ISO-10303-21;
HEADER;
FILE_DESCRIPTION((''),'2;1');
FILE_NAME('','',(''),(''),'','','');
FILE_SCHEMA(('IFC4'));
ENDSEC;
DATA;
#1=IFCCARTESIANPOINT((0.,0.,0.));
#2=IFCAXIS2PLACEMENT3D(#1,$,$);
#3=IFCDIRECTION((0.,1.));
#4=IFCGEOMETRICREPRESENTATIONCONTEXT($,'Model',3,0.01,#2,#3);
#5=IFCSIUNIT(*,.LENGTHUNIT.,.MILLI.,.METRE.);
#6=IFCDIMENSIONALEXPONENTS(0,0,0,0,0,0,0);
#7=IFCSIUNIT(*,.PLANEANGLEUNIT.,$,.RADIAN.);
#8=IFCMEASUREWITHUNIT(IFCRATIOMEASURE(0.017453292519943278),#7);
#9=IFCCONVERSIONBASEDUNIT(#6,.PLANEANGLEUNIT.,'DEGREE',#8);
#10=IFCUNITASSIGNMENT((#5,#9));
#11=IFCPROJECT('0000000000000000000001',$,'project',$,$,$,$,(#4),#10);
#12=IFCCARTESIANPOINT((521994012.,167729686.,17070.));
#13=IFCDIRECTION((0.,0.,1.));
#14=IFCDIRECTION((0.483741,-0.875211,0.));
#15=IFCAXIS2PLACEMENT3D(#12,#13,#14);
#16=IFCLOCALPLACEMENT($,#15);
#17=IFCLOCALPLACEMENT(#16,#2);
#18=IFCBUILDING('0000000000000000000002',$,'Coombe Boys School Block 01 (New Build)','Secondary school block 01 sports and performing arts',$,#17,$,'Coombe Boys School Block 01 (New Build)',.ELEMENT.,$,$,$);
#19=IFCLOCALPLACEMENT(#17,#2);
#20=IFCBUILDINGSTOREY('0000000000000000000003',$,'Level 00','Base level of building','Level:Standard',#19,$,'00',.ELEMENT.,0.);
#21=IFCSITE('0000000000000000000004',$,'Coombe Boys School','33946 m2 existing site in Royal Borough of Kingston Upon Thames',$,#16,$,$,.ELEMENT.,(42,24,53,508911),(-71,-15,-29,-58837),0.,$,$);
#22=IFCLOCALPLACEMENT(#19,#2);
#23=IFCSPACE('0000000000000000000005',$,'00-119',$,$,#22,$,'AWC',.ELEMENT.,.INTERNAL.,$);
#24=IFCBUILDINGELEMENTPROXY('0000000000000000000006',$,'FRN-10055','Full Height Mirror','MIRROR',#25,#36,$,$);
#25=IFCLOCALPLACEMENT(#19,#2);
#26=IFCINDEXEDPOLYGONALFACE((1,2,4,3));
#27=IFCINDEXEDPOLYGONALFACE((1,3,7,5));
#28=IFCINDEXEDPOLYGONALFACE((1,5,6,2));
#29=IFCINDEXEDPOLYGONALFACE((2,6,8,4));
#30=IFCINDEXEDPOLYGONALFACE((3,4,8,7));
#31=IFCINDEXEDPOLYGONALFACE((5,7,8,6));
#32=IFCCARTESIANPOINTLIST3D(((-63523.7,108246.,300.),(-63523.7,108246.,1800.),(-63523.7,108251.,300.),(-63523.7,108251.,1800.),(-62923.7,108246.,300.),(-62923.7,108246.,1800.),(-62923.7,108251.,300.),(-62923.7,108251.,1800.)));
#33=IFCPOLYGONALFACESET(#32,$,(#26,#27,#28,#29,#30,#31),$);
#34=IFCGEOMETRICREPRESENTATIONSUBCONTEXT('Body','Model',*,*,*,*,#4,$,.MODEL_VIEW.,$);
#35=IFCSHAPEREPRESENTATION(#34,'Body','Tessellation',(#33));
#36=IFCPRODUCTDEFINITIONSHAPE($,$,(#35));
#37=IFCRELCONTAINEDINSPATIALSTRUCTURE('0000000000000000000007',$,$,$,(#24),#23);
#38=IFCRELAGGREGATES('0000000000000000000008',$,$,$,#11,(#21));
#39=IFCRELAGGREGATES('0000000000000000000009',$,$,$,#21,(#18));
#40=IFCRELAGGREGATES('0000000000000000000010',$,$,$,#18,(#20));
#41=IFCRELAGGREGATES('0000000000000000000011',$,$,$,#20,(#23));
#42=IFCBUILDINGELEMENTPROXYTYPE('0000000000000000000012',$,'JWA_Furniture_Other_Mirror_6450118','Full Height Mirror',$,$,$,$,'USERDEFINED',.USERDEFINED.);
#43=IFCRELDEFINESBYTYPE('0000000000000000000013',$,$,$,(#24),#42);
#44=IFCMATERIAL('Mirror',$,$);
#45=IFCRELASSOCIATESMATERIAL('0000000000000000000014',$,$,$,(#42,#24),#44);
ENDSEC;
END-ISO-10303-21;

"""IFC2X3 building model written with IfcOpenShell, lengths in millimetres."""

from ifc_helpers import new_model, entity, si_unit, converted_unit, direction, frame, origin, origin_2d_with_axis, place, context, subcontext, project, spatial, rectangle, extrude, source, transform, mapped, material, type_object, type_shapes, element, save


model = new_model("IFC2X3")

# Units and contexts
model_context = context("Model", 3, precision=0.01, world=origin(), true_north=direction((0.0, 1.0)))
body_context = subcontext(model_context, "Body", "Model", "MODEL_VIEW")
ifc_project = project(units=[si_unit("LENGTHUNIT", "METRE", prefix="MILLI"), converted_unit("PLANEANGLEUNIT", "DEGREE", entity("IfcRatioMeasure", 0.017453292519943278), si_unit("PLANEANGLEUNIT", "RADIAN"), dimensions=[0, 0, 0, 0, 0, 0, 0])], contexts=[model_context])

# Site, building, storey
site_placement = place(None, frame((521994012.0, 167729686.0, 17070.0), z_axis=(0.0, 0.0, 1.0), x_axis=(0.483741, -0.875211, 0.0)))
site = spatial("IfcSite", under=ifc_project, at=site_placement, Name="Coombe Boys School", Description="33946 m2 existing site in Royal Borough of Kingston Upon Thames", CompositionType="ELEMENT", RefLatitude=(42, 24, 53, 508911), RefLongitude=(-71, -15, -29, -58837), RefElevation=0.0)
building_placement = place(site_placement, origin())
building = spatial("IfcBuilding", under=site, at=building_placement, Name="Coombe Boys School Block 01 (New Build)", Description="Secondary school block 01 sports and performing arts", LongName="Coombe Boys School Block 01 (New Build)", CompositionType="ELEMENT")
storey_placement = place(building_placement, origin())
storey = spatial("IfcBuildingStorey", under=building, at=storey_placement, Name="Level 00", Description="Base level of building", ObjectType="Level:Standard", LongName="00", CompositionType="ELEMENT", Elevation=0.0)

# Shared definitions
space_1_placement = place(storey_placement, origin())
space_1 = spatial("IfcSpace", under=storey, at=space_1_placement, Name="00-119", LongName="AWC", CompositionType="ELEMENT", InteriorOrExteriorSpace="INTERNAL")

# Building element proxy
ifc_material_1 = material(Name="Mirror")
building_element_proxy_type = type_object("IfcBuildingElementProxyType", Name="JWA_Furniture_Other_Mirror_6450118", Description="Full Height Mirror", ElementType="USERDEFINED", PredefinedType="USERDEFINED", material=ifc_material_1)
shared_shape_1 = source(origin(), body_context, "Body", "SweptSolid", [
    extrude(rectangle(XDim=5.0, YDim=600.0, at=origin_2d_with_axis()), frame((0.0, -2.5, 0.0), z_axis=(0.0, 0.0, 1.0), x_axis=(0.0, 1.0, 0.0)), (0.0, 0.0, 1.0), 1500.0),
])
type_shapes(building_element_proxy_type, [shared_shape_1])
proxy_placement = place(space_1_placement, frame((-63223.7, 108246.0, 300.0), z_axis=(0.0, 0.0, 1.0), x_axis=(-1.0, 0.0, 0.0)))
element("IfcBuildingElementProxy", 1, at=proxy_placement, inside=space_1, type_object=building_element_proxy_type, material=ifc_material_1, Name="FRN-10055", Description="Full Height Mirror", ObjectType="MIRROR", context=body_context, shape_type="MappedRepresentation", body=[
    mapped(shared_shape_1, transform((0.0, 0.0, 0.0), scale=1.0)),
])

save(model, "model.ifc")
